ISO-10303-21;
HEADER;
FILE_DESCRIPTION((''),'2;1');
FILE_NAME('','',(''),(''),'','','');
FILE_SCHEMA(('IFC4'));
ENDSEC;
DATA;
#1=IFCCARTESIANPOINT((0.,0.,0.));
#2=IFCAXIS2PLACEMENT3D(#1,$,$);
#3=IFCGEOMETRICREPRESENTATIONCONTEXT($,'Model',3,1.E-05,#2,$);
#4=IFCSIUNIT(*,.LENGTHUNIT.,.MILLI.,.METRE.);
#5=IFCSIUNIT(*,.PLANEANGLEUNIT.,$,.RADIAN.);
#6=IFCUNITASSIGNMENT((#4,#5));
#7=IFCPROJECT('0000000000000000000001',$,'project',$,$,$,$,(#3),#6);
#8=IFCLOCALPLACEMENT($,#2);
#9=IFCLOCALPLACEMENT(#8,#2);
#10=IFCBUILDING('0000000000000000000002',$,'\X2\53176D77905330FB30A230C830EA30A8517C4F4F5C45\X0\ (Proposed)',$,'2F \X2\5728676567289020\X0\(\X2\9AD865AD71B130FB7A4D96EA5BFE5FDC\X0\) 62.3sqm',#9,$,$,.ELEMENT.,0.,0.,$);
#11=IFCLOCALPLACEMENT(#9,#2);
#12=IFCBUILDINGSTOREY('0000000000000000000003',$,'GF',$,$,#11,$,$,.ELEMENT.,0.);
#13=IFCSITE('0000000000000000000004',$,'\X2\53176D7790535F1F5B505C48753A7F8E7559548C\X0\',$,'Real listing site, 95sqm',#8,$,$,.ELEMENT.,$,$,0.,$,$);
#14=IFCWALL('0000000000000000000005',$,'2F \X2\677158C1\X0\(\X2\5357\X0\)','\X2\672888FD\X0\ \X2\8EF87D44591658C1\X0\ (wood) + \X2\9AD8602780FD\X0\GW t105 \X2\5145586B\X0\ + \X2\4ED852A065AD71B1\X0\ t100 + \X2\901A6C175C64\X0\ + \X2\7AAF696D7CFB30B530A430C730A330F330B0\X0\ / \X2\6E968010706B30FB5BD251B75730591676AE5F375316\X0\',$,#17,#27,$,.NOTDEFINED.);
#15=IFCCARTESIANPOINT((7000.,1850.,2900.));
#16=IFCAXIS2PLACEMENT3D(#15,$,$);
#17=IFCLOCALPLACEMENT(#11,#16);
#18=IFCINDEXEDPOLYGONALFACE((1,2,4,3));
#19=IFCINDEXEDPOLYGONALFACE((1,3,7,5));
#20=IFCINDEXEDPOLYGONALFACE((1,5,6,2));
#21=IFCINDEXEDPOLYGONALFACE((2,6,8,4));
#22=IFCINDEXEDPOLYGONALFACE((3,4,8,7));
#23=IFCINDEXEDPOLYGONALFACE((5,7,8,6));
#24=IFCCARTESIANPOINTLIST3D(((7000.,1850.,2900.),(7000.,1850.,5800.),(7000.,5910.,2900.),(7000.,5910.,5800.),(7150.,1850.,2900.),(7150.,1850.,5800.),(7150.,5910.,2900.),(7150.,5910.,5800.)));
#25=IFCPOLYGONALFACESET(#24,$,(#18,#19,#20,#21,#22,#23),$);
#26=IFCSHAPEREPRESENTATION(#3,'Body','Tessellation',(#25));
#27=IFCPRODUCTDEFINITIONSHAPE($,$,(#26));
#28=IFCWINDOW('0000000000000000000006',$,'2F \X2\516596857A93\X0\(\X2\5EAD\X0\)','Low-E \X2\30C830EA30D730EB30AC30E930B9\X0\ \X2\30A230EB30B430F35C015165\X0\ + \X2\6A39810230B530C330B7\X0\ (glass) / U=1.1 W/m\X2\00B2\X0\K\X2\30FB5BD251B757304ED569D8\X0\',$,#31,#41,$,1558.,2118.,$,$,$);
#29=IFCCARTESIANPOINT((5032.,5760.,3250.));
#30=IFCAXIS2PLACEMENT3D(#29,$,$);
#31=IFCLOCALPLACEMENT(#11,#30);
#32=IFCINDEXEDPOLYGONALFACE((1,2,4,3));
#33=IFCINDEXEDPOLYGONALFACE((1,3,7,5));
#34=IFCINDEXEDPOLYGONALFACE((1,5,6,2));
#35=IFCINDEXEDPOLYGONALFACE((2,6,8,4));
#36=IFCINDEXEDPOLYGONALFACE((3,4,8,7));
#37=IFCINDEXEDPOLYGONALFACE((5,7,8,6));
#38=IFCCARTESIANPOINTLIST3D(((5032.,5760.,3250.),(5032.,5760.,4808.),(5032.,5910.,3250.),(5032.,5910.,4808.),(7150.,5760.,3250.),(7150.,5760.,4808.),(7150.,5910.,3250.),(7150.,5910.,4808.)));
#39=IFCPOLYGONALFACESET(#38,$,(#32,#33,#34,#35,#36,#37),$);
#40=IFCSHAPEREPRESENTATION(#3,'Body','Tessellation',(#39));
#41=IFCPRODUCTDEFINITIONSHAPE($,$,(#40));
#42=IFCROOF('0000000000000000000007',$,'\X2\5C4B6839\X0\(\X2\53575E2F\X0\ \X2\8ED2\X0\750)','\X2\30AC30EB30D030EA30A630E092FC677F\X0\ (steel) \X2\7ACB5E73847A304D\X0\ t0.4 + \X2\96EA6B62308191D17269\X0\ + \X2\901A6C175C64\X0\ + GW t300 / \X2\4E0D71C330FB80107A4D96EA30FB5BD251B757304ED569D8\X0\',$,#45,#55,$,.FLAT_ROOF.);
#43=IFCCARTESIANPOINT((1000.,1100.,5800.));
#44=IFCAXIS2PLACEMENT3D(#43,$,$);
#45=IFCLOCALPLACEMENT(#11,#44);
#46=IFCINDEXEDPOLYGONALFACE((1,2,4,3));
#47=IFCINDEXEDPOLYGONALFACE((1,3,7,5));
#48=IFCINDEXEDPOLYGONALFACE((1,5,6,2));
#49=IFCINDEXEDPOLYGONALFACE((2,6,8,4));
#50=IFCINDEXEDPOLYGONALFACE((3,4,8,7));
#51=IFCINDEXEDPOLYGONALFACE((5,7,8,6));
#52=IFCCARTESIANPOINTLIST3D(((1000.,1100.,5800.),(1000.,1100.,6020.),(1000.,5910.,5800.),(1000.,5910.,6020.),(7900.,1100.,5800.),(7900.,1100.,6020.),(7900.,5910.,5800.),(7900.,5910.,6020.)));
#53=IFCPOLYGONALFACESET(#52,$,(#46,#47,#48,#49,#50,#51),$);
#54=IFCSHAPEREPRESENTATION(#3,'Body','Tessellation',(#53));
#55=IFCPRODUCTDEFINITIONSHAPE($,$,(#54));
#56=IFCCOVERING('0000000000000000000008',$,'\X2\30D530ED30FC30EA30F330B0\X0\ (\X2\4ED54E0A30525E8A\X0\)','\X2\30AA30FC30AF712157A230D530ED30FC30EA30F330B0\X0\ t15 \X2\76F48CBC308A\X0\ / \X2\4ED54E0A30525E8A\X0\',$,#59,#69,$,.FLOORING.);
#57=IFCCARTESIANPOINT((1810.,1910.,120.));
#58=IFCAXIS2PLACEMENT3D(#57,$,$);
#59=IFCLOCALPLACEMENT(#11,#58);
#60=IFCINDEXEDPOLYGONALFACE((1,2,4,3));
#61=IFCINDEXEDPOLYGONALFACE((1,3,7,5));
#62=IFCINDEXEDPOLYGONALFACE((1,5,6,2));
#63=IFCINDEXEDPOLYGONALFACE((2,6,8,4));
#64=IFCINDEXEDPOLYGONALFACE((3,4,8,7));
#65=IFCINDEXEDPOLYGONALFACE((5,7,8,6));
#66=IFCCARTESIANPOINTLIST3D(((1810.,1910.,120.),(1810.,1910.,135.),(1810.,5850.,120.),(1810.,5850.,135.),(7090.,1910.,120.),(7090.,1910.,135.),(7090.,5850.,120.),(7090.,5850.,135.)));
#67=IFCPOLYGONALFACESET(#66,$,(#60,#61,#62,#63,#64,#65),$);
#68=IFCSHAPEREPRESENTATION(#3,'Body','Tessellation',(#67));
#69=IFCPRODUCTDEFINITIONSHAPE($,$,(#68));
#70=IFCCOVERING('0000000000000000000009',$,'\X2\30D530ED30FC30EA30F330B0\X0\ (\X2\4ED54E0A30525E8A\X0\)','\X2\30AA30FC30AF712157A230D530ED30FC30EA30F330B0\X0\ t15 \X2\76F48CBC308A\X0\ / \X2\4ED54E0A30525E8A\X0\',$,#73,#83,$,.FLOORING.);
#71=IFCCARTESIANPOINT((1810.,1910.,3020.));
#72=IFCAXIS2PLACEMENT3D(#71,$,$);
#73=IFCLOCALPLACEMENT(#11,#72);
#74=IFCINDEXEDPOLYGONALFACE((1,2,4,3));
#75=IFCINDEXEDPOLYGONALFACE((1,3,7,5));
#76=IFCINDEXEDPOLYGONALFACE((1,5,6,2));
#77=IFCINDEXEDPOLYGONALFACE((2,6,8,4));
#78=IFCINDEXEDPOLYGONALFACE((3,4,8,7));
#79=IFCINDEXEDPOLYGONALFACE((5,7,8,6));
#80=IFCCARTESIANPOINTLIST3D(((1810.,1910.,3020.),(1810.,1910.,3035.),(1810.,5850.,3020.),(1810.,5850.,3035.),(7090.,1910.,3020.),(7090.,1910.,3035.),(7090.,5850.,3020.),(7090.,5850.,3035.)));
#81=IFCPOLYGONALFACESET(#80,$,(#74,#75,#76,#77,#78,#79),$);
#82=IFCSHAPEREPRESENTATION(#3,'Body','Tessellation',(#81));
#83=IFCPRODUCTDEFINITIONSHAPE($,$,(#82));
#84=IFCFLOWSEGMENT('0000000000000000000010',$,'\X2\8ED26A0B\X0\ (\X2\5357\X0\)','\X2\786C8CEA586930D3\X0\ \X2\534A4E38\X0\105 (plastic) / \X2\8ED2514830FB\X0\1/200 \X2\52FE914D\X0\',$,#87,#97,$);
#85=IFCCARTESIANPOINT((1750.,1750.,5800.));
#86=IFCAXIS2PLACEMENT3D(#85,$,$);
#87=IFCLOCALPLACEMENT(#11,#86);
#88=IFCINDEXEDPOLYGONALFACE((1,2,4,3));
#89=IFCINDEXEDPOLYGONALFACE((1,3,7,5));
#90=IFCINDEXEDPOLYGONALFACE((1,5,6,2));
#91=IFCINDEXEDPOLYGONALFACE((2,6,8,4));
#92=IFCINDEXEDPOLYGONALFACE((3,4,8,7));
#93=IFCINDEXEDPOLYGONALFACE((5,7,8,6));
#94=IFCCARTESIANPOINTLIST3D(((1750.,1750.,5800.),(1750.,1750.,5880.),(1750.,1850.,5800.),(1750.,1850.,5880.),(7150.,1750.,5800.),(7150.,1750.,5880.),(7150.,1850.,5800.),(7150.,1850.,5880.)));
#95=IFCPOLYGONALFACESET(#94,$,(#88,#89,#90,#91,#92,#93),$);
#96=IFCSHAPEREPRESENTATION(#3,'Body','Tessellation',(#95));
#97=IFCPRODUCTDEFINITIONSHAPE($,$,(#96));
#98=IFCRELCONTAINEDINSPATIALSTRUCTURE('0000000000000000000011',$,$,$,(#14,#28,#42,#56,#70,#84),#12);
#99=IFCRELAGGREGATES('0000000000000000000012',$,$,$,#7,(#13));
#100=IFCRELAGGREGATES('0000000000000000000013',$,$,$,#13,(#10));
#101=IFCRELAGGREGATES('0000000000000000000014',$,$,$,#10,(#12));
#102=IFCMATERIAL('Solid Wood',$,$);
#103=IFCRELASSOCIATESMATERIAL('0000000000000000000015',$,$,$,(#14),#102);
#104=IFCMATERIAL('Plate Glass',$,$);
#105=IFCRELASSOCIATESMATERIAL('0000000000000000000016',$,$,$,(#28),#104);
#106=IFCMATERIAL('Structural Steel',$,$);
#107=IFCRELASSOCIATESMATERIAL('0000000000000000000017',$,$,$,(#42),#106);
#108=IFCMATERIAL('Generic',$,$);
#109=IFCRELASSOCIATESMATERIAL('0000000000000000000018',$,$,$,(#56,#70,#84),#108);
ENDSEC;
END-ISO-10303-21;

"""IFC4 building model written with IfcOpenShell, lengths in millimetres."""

from ifc_helpers import new_model, si_unit, frame, frame_2d, origin, place, context, project, spatial, rectangle, extrude, material, element, fill, save


model = new_model("IFC4")

# Units and contexts
model_context = context("Model", 3, precision=1e-05, world=origin())
ifc_project = project(units=[si_unit("LENGTHUNIT", "METRE", prefix="MILLI"), si_unit("PLANEANGLEUNIT", "RADIAN")], contexts=[model_context])

# Site, building, storey
site_placement = place(None, origin())
site = spatial("IfcSite", under=ifc_project, at=site_placement, Name="北海道弟子屈町美留和", ObjectType="Real listing site, 95sqm", CompositionType="ELEMENT", RefElevation=0.0)
building_placement = place(site_placement, origin())
building = spatial("IfcBuilding", under=site, at=building_placement, Name="北海道・アトリエ兼住居 (Proposed)", ObjectType="2F 在来木造(高断熱・積雪対応) 62.3sqm", CompositionType="ELEMENT", ElevationOfRefHeight=0.0, ElevationOfTerrain=0.0)
storey_placement = place(building_placement, origin())
storey = spatial("IfcBuildingStorey", under=building, at=storey_placement, Name="GF", CompositionType="ELEMENT", Elevation=0.0)

# Shared definitions
ifc_material_1 = material(Name="Solid Wood")

# Wall, opening, window
ifc_material_2 = material(Name="Plate Glass")
wall_1_placement = place(storey_placement, frame((7000.0, 1850.0, 2900.0)))
wall_1 = element("IfcWall", 1, at=wall_1_placement, inside=storey, material=ifc_material_1, Name="2F 東壁(南)", Description="木製 軸組外壁 (wood) + 高性能GW t105 充填 + 付加断熱 t100 + 通気層 + 窯業系サイディング / 準耐火・寒冷地外皮強化", PredefinedType="NOTDEFINED", context=model_context, shape_type="SweptSolid", body=[
    extrude(rectangle(XDim=150.0, YDim=4060.0, at=frame_2d((75.0, 2030.0))), frame((7000.0, 1850.0, 2900.0)), (0.0, 0.0, 1.0), 2900.0),
])
opening_1_placement = place(storey_placement, frame((5032.0, 5760.0, 3250.0)))
opening_1 = element("IfcOpeningElement", 2, at=opening_1_placement, cuts=wall_1, PredefinedType="NOTDEFINED", context=model_context, shape_type="SweptSolid", body=[
    extrude(rectangle(XDim=2118.0, YDim=150.0, at=frame_2d((1059.0, 75.0))), frame((5032.0, 5760.0, 3250.0)), (0.0, 0.0, 1.0), 1558.0),
])
window_1_placement = place(storey_placement, frame((5032.0, 5760.0, 3250.0)))
window_1 = element("IfcWindow", 3, at=window_1_placement, inside=storey, material=ifc_material_2, Name="2F 入隅窓(庭)", Description="Low-E トリプルガラス アルゴン封入 + 樹脂サッシ (glass) / U=1.1 W/m²K・寒冷地仕様", OverallHeight=1558.0, OverallWidth=2118.0, context=model_context, shape_type="SweptSolid", body=[
    extrude(rectangle(XDim=2118.0, YDim=150.0, at=frame_2d((1059.0, 75.0))), frame((5032.0, 5760.0, 3250.0)), (0.0, 0.0, 1.0), 1558.0),
])
fill(opening_1, window_1)

# Roof
ifc_material_3 = material(Name="Structural Steel")
for number, where, name in (
    (4, (1000.0, 1100.0, 5800.0), "屋根(南帯 軒750)"),
):
    element("IfcRoof", number, at=place(storey_placement, frame(where)), inside=storey, material=ifc_material_3, Name=name, Description="ガルバリウム鋼板 (steel) 立平葺き t0.4 + 雪止め金物 + 通気層 + GW t300 / 不燃・耐積雪・寒冷地仕様", PredefinedType="FLAT_ROOF", context=model_context, shape_type="SweptSolid", body=[
        extrude(rectangle(XDim=6900.0, YDim=4810.0, at=frame_2d((3450.0, 2405.0))), frame((1000.0, 1100.0, 5800.0)), (0.0, 0.0, 1.0), 220.0),
    ])

# Coverings
ifc_material_4 = material(Name="Generic")
covering_1_placement = place(storey_placement, frame((1810.0, 1910.0, 120.0)))
element("IfcCovering", 5, at=covering_1_placement, inside=storey, material=ifc_material_4, Name="フローリング (仕上げ床)", Description="オーク無垢フローリング t15 直貼り / 仕上げ床", PredefinedType="FLOORING", context=model_context, shape_type="SweptSolid", body=[
    extrude(rectangle(XDim=5280.0, YDim=3940.0, at=frame_2d((2640.0, 1970.0))), frame((1810.0, 1910.0, 120.0)), (0.0, 0.0, 1.0), 15.0),
])
covering_2_placement = place(storey_placement, frame((1810.0, 1910.0, 3020.0)))
element("IfcCovering", 6, at=covering_2_placement, inside=storey, material=ifc_material_4, Name="フローリング (仕上げ床)", Description="オーク無垢フローリング t15 直貼り / 仕上げ床", PredefinedType="FLOORING", context=model_context, shape_type="SweptSolid", body=[
    extrude(rectangle(XDim=5280.0, YDim=3940.0, at=frame_2d((2640.0, 1970.0))), frame((1810.0, 1910.0, 3020.0)), (0.0, 0.0, 1.0), 15.0),
])

# Flow segment
flow_segment_placement = place(storey_placement, frame((1750.0, 1750.0, 5800.0)))
element("IfcFlowSegment", 7, at=flow_segment_placement, inside=storey, material=ifc_material_4, Name="軒樋 (南)", Description="硬質塩ビ 半丸105 (plastic) / 軒先・1/200 勾配", context=model_context, shape_type="SweptSolid", body=[
    extrude(rectangle(XDim=5400.0, YDim=100.0, at=frame_2d((2700.0, 50.0))), frame((1750.0, 1750.0, 5800.0)), (0.0, 0.0, 1.0), 80.0),
])

save(model, "model.ifc")
